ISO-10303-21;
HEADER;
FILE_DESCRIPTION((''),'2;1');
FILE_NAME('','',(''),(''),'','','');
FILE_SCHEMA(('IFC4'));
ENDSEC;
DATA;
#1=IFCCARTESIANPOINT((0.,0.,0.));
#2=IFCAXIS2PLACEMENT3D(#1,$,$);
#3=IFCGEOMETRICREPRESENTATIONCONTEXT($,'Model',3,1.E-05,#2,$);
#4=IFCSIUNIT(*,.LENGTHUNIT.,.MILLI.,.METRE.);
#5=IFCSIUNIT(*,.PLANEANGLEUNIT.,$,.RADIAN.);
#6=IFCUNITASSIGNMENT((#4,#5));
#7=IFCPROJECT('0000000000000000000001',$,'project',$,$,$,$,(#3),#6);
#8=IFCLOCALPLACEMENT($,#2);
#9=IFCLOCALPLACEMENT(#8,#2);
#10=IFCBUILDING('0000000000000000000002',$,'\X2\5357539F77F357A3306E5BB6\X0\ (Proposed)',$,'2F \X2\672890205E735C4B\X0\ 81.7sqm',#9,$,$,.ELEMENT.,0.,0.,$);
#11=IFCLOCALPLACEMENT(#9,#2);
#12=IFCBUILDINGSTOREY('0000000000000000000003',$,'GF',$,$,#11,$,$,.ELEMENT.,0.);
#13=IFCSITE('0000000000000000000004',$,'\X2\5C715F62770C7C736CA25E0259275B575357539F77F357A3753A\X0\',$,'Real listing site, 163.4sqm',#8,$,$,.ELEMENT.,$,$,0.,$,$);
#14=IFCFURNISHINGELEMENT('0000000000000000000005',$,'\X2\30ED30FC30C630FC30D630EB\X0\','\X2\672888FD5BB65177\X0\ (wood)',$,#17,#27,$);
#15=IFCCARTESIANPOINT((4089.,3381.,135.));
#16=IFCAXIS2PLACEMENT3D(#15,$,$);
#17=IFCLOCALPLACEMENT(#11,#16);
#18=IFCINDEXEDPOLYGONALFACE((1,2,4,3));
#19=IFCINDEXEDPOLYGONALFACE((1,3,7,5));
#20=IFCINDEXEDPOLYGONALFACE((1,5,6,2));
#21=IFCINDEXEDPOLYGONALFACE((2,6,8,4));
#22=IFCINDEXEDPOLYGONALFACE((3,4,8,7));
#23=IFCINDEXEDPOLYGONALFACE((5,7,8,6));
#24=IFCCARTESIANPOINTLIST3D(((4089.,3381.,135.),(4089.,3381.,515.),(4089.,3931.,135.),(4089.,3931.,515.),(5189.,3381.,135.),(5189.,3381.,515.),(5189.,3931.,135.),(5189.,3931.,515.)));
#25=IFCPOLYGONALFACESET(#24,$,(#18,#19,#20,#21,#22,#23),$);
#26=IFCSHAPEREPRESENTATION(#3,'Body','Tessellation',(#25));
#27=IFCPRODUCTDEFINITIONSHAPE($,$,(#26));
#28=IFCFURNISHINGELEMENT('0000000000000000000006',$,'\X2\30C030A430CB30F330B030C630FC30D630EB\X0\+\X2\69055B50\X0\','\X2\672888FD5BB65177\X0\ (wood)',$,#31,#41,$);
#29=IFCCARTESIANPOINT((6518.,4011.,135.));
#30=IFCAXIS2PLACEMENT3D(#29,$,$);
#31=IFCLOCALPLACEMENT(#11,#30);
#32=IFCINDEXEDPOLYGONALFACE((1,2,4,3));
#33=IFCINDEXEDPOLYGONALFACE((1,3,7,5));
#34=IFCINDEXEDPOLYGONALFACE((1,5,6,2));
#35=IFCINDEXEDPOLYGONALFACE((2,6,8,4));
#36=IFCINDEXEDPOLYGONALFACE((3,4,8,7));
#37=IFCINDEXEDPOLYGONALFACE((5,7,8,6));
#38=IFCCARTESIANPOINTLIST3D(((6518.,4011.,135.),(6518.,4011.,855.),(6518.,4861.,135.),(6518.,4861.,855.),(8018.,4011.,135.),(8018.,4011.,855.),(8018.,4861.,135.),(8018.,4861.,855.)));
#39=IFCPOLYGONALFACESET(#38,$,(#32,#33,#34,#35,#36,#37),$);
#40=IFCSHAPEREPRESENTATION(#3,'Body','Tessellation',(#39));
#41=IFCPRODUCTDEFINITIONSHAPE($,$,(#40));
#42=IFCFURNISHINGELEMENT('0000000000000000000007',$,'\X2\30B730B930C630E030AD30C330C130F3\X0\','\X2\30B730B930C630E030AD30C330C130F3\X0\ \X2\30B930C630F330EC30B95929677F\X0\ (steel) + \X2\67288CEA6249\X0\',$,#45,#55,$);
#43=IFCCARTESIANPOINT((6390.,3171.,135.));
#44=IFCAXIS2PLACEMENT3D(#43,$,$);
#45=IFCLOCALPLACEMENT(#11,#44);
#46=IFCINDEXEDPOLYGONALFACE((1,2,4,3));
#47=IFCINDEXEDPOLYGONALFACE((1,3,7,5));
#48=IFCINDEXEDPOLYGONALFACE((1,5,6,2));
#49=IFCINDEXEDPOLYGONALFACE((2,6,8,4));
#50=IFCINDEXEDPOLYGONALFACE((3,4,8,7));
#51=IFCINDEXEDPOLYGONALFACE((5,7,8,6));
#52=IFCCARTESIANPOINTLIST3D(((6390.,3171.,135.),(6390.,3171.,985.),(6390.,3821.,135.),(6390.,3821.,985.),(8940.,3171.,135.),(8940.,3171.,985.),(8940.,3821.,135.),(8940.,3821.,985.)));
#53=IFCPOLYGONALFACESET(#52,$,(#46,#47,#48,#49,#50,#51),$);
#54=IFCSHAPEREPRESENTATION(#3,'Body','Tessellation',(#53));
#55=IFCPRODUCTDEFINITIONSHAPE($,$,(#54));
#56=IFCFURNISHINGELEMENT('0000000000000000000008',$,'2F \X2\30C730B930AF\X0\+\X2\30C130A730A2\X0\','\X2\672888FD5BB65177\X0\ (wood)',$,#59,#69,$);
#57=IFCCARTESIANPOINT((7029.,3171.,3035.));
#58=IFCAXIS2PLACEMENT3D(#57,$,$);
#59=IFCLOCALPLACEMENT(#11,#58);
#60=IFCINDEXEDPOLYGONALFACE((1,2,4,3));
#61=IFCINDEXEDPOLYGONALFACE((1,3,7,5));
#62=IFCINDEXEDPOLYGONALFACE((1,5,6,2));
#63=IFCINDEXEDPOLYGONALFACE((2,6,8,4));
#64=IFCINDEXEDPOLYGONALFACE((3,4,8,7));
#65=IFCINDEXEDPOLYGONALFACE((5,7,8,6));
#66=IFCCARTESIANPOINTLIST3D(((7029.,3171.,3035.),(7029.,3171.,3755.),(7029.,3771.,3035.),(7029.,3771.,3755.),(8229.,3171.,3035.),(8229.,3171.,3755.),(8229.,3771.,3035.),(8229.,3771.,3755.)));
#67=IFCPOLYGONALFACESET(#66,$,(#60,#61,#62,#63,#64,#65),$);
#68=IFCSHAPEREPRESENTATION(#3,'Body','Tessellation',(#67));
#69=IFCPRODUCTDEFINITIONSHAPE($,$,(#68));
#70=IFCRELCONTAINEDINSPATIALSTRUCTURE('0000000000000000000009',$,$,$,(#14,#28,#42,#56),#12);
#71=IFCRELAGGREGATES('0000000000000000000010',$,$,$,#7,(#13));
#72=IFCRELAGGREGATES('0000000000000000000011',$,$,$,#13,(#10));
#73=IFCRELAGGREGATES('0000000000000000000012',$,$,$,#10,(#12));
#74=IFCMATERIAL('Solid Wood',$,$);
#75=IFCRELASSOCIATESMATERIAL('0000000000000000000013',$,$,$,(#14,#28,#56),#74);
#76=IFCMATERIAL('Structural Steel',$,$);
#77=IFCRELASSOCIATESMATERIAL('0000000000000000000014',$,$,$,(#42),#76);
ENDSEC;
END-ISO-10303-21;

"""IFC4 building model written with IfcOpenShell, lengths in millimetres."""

from ifc_helpers import new_model, si_unit, frame, frame_2d, origin, place, context, project, spatial, rectangle, extrude, material, element, save


model = new_model("IFC4")

# Units and contexts
model_context = context("Model", 3, precision=1e-05, world=origin())
ifc_project = project(units=[si_unit("LENGTHUNIT", "METRE", prefix="MILLI"), si_unit("PLANEANGLEUNIT", "RADIAN")], contexts=[model_context])

# Site, building, storey
site_placement = place(None, origin())
site = spatial("IfcSite", under=ifc_project, at=site_placement, Name="山形県米沢市大字南原石垣町", ObjectType="Real listing site, 163.4sqm", CompositionType="ELEMENT", RefElevation=0.0)
building_placement = place(site_placement, origin())
building = spatial("IfcBuilding", under=site, at=building_placement, Name="南原石垣の家 (Proposed)", ObjectType="2F 木造平屋 81.7sqm", CompositionType="ELEMENT", ElevationOfRefHeight=0.0, ElevationOfTerrain=0.0)
storey_placement = place(building_placement, origin())
storey = spatial("IfcBuildingStorey", under=building, at=storey_placement, Name="GF", CompositionType="ELEMENT", Elevation=0.0)

# Shared definitions
ifc_material_1 = material(Name="Solid Wood")

# Shared definitions
ifc_material_2 = material(Name="Structural Steel")

# Furnishing elements
furnishing_1_placement = place(storey_placement, frame((4089.0, 3381.0, 135.0)))
element("IfcFurnishingElement", 1, at=furnishing_1_placement, inside=storey, material=ifc_material_1, Name="ローテーブル", Description="木製家具 (wood)", context=model_context, shape_type="SweptSolid", body=[
    extrude(rectangle(XDim=1100.0, YDim=550.0, at=frame_2d((550.0, 275.0))), frame((4089.0, 3381.0, 135.0)), (0.0, 0.0, 1.0), 380.0),
])
furnishing_2_placement = place(storey_placement, frame((6518.0, 4011.0, 135.0)))
element("IfcFurnishingElement", 2, at=furnishing_2_placement, inside=storey, material=ifc_material_1, Name="ダイニングテーブル+椅子", Description="木製家具 (wood)", context=model_context, shape_type="SweptSolid", body=[
    extrude(rectangle(XDim=1500.0, YDim=850.0, at=frame_2d((750.0, 425.0))), frame((6518.0, 4011.0, 135.0)), (0.0, 0.0, 1.0), 720.0),
])
furnishing_3_placement = place(storey_placement, frame((6390.0, 3171.0, 135.0)))
element("IfcFurnishingElement", 3, at=furnishing_3_placement, inside=storey, material=ifc_material_2, Name="システムキッチン", Description="システムキッチン ステンレス天板 (steel) + 木質扉", context=model_context, shape_type="SweptSolid", body=[
    extrude(rectangle(XDim=2550.0, YDim=650.0, at=frame_2d((1275.0, 325.0))), frame((6390.0, 3171.0, 135.0)), (0.0, 0.0, 1.0), 850.0),
])
furnishing_4_placement = place(storey_placement, frame((7029.0, 3171.0, 3035.0)))
element("IfcFurnishingElement", 4, at=furnishing_4_placement, inside=storey, material=ifc_material_1, Name="2F デスク+チェア", Description="木製家具 (wood)", context=model_context, shape_type="SweptSolid", body=[
    extrude(rectangle(XDim=1200.0, YDim=600.0, at=frame_2d((600.0, 300.0))), frame((7029.0, 3171.0, 3035.0)), (0.0, 0.0, 1.0), 720.0),
])

save(model, "model.ifc")
